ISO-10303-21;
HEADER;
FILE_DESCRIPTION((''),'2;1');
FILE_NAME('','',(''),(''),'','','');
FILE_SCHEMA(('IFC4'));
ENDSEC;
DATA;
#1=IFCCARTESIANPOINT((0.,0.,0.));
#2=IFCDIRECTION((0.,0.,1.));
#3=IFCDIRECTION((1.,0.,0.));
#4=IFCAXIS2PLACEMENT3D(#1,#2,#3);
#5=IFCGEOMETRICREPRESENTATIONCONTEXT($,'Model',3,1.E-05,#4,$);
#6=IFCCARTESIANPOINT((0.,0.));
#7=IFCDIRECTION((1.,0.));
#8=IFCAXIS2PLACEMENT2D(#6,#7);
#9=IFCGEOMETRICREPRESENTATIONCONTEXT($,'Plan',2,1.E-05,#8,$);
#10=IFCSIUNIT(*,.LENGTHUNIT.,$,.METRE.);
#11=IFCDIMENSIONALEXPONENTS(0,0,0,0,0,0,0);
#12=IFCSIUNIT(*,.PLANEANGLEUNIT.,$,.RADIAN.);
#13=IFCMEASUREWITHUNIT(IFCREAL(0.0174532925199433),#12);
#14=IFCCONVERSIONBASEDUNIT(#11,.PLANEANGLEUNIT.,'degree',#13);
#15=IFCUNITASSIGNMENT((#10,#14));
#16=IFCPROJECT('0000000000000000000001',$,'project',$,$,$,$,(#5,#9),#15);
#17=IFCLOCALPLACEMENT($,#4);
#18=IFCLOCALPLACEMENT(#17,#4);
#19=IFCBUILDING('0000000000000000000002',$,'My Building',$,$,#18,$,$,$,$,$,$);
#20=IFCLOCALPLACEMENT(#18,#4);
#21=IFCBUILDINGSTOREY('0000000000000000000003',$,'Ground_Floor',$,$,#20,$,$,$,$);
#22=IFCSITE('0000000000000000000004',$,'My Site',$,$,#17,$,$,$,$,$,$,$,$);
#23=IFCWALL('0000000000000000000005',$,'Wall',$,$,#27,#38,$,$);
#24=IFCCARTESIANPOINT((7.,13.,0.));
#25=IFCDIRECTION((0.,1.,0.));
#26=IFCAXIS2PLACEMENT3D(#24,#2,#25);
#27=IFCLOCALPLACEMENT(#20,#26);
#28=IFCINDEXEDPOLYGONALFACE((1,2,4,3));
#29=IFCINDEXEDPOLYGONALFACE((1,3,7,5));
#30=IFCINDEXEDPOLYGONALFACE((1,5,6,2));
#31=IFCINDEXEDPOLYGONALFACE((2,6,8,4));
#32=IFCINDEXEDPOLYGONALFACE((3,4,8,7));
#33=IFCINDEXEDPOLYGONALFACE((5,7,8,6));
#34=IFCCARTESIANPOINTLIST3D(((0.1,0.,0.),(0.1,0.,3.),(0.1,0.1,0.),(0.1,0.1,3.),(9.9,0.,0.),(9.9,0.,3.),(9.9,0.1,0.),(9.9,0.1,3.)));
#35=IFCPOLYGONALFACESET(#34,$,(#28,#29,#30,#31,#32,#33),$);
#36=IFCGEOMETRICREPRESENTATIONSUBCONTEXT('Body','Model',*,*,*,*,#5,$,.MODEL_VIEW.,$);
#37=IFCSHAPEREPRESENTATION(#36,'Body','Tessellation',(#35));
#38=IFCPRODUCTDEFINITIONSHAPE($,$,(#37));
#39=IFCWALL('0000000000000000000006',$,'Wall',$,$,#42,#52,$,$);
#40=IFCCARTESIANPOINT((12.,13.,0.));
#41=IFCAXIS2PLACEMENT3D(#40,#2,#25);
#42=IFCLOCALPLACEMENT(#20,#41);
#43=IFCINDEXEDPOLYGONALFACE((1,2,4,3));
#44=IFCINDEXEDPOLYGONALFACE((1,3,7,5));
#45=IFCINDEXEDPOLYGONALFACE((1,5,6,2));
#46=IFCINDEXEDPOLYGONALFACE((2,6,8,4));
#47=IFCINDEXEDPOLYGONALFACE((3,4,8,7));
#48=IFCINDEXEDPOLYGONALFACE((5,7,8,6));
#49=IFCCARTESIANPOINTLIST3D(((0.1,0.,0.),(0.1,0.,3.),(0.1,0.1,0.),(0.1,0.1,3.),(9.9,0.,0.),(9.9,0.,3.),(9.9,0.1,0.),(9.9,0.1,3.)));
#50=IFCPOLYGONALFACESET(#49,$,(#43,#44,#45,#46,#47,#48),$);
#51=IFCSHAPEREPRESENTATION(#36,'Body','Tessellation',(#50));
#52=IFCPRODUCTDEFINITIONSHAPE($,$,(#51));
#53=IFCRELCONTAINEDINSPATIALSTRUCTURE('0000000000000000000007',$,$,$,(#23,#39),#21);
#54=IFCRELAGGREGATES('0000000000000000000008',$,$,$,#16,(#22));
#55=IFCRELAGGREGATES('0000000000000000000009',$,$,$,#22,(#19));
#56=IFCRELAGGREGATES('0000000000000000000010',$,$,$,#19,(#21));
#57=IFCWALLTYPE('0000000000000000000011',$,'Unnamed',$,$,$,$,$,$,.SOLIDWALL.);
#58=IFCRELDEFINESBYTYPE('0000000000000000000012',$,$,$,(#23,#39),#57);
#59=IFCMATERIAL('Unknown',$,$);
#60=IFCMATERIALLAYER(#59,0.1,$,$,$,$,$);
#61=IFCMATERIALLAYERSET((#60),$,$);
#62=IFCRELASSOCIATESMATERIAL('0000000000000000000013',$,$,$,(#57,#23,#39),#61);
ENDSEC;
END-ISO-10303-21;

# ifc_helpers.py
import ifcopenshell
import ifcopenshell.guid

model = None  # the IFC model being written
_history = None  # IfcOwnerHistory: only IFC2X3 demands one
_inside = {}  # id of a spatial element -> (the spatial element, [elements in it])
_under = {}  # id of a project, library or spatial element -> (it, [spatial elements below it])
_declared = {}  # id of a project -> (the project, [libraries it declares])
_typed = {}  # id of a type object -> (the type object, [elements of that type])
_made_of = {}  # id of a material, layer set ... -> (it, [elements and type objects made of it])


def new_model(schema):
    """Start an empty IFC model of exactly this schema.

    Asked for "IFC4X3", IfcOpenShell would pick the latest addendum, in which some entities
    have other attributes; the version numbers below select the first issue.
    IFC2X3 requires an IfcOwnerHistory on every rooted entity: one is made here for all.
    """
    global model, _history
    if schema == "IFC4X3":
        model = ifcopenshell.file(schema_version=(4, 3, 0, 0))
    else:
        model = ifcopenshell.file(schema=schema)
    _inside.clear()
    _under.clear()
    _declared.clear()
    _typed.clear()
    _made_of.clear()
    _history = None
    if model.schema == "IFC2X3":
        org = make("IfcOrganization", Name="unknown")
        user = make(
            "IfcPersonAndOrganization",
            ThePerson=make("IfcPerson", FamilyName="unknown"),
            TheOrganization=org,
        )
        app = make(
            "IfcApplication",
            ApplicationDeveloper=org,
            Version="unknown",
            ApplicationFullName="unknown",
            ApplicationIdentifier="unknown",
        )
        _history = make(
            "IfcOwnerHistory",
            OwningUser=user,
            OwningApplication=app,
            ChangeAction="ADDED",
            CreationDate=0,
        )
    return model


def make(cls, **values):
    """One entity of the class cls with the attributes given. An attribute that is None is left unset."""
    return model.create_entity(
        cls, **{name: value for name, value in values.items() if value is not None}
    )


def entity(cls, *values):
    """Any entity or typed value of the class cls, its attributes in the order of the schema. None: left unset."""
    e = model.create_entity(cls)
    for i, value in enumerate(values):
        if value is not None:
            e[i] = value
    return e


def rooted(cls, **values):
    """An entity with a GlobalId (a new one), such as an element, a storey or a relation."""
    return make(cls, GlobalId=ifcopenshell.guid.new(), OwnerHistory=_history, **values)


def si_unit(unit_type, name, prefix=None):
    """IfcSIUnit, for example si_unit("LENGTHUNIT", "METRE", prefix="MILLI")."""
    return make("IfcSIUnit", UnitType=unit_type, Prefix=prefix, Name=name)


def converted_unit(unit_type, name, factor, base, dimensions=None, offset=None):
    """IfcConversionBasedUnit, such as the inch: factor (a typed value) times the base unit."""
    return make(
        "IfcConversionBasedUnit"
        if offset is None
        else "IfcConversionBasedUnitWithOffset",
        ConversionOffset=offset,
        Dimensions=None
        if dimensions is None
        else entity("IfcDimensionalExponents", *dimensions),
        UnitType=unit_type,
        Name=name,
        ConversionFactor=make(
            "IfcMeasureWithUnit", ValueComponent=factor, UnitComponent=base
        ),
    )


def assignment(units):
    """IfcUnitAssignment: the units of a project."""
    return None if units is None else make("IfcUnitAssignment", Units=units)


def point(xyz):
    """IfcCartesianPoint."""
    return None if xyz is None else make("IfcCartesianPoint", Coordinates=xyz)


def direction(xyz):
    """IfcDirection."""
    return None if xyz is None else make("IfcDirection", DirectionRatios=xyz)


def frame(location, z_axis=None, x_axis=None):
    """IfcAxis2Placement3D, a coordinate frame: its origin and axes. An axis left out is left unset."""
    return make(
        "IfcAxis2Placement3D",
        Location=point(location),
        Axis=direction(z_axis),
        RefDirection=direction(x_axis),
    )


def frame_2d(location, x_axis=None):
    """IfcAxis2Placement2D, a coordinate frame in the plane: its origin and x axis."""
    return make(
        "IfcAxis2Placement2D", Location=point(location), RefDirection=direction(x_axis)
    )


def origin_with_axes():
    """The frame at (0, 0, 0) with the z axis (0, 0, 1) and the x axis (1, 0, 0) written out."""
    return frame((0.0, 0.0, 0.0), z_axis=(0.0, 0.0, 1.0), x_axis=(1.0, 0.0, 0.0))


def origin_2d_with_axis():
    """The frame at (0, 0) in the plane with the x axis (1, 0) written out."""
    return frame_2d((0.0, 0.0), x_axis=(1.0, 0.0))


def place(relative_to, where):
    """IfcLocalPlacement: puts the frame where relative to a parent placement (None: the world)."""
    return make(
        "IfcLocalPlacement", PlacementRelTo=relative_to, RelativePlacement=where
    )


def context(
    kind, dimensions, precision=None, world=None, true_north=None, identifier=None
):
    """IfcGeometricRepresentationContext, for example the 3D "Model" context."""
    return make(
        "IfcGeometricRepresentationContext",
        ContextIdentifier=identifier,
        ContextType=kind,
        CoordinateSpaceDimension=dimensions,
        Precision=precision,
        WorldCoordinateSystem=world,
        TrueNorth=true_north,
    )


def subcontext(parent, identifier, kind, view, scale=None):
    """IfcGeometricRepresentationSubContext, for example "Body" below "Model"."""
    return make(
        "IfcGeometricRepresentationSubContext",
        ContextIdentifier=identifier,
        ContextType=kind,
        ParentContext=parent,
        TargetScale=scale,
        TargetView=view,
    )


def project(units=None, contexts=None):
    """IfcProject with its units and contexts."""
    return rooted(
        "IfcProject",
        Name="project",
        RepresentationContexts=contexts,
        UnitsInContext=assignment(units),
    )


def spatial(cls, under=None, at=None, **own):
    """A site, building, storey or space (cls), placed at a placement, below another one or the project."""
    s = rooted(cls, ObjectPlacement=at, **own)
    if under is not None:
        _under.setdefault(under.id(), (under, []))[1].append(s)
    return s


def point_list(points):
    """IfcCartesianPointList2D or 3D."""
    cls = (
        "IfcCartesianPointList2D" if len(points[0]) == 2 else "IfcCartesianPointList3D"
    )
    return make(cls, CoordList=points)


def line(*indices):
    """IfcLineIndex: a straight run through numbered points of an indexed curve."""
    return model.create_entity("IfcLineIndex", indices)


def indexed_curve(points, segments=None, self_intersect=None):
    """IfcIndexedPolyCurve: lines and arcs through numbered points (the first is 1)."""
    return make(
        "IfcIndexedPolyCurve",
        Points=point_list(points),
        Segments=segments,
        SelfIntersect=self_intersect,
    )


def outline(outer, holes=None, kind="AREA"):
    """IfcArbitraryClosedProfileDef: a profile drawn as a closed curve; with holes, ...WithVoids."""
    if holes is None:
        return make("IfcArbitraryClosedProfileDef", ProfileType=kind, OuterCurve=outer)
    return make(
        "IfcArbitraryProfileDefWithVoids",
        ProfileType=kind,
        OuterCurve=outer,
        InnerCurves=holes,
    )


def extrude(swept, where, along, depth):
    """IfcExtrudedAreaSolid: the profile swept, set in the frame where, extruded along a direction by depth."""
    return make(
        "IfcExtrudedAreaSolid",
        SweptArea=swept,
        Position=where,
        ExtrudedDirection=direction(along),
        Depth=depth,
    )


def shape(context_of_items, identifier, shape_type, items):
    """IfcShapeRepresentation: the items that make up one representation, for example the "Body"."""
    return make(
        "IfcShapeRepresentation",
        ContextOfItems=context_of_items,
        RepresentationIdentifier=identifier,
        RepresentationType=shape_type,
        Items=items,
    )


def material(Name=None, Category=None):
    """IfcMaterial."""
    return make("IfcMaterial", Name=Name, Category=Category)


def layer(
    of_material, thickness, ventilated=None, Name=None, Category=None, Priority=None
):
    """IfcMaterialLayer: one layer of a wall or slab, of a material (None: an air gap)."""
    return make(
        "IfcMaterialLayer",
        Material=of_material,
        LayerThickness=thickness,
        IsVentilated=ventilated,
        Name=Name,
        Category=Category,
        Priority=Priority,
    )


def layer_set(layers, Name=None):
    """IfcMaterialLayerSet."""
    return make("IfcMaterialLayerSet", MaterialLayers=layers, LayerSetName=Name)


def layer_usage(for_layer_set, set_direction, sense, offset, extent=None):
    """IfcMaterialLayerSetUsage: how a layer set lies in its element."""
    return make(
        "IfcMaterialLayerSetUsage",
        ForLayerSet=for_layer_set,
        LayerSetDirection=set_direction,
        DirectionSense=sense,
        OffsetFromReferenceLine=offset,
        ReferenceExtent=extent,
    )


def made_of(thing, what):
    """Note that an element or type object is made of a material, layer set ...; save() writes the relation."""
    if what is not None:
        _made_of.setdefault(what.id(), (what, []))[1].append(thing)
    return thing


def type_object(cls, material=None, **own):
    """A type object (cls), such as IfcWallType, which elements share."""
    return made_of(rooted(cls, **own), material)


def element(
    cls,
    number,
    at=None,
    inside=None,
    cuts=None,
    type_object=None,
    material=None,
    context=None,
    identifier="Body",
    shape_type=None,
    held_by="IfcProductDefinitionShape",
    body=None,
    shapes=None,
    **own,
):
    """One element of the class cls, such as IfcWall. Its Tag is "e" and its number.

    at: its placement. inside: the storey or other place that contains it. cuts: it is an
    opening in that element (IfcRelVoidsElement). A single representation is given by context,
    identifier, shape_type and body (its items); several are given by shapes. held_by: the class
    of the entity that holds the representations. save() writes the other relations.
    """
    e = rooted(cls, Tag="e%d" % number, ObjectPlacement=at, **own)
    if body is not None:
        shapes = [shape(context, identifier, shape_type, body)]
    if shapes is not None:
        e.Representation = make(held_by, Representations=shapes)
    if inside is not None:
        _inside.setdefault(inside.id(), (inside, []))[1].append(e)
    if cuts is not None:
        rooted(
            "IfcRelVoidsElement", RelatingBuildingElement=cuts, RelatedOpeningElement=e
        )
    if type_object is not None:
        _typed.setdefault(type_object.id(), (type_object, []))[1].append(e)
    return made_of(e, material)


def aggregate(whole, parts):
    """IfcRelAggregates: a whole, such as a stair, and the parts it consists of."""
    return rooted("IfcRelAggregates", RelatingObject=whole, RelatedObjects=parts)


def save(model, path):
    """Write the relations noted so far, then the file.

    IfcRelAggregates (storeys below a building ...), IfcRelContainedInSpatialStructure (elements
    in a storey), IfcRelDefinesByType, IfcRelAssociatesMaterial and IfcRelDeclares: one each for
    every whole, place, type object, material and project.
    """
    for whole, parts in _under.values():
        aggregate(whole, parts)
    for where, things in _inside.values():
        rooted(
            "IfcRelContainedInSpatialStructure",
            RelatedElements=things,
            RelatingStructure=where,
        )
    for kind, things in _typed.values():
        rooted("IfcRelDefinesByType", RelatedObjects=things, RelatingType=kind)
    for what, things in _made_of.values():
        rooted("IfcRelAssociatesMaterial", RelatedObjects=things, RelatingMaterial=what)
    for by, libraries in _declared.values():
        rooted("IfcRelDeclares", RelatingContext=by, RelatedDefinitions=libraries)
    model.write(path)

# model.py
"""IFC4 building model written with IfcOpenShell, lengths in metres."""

from ifc_helpers import new_model, entity, si_unit, converted_unit, frame, origin_with_axes, origin_2d_with_axis, place, context, subcontext, project, spatial, line, indexed_curve, outline, extrude, material, layer, layer_set, layer_usage, type_object, element, save


model = new_model("IFC4")

# Units and contexts
model_context = context("Model", 3, precision=1e-05, world=origin_with_axes())
plan_context = context("Plan", 2, precision=1e-05, world=origin_2d_with_axis())
body_context_1 = subcontext(model_context, "Body", "Model", "MODEL_VIEW")
ifc_project = project(units=[si_unit("LENGTHUNIT", "METRE"), converted_unit("PLANEANGLEUNIT", "degree", entity("IfcReal", 0.0174532925199433), si_unit("PLANEANGLEUNIT", "RADIAN"), dimensions=[0, 0, 0, 0, 0, 0, 0])], contexts=[model_context, plan_context])

# Site, building, storey
site_placement = place(None, origin_with_axes())
site = spatial("IfcSite", under=ifc_project, at=site_placement, Name="My Site")
building_placement = place(site_placement, origin_with_axes())
building = spatial("IfcBuilding", under=site, at=building_placement, Name="My Building")
storey_placement = place(building_placement, origin_with_axes())
storey = spatial("IfcBuildingStorey", under=building, at=storey_placement, Name="Ground_Floor")

# Walls
ifc_material = material(Name="Unknown")
ifc_layer = layer(ifc_material, 0.1)
ifc_layer_set = layer_set([ifc_layer])
ifc_layer_usage_1 = layer_usage(ifc_layer_set, "AXIS2", "POSITIVE", 0.0)
wall_type = type_object("IfcWallType", Name="Unnamed", PredefinedType="SOLIDWALL", material=ifc_layer_set)
wall_1_placement = place(storey_placement, frame((7.0, 13.0, 0.0), z_axis=(0.0, 0.0, 1.0), x_axis=(0.0, 1.0, 0.0)))
element("IfcWall", 1, at=wall_1_placement, inside=storey, type_object=wall_type, material=ifc_layer_usage_1, Name="Wall", context=body_context_1, shape_type="SweptSolid", body=[
    extrude(outline(indexed_curve([(0.1, 0.0), (0.1, 0.1), (9.9, 0.1), (9.9, 0.0)], segments=[line(1, 2, 3, 4, 1)])), origin_with_axes(), (0.0, 0.0, 1.0), 3.0),
])
ifc_layer_usage_2 = layer_usage(ifc_layer_set, "AXIS2", "POSITIVE", 0.0)
wall_2_placement = place(storey_placement, frame((12.0, 13.0, 0.0), z_axis=(0.0, 0.0, 1.0), x_axis=(0.0, 1.0, 0.0)))
element("IfcWall", 2, at=wall_2_placement, inside=storey, type_object=wall_type, material=ifc_layer_usage_2, Name="Wall", context=body_context_1, shape_type="SweptSolid", body=[
    extrude(outline(indexed_curve([(0.1, 0.0), (0.1, 0.1), (9.9, 0.1), (9.9, 0.0)], segments=[line(1, 2, 3, 4, 1)])), origin_with_axes(), (0.0, 0.0, 1.0), 3.0),
])

save(model, "model.ifc")
